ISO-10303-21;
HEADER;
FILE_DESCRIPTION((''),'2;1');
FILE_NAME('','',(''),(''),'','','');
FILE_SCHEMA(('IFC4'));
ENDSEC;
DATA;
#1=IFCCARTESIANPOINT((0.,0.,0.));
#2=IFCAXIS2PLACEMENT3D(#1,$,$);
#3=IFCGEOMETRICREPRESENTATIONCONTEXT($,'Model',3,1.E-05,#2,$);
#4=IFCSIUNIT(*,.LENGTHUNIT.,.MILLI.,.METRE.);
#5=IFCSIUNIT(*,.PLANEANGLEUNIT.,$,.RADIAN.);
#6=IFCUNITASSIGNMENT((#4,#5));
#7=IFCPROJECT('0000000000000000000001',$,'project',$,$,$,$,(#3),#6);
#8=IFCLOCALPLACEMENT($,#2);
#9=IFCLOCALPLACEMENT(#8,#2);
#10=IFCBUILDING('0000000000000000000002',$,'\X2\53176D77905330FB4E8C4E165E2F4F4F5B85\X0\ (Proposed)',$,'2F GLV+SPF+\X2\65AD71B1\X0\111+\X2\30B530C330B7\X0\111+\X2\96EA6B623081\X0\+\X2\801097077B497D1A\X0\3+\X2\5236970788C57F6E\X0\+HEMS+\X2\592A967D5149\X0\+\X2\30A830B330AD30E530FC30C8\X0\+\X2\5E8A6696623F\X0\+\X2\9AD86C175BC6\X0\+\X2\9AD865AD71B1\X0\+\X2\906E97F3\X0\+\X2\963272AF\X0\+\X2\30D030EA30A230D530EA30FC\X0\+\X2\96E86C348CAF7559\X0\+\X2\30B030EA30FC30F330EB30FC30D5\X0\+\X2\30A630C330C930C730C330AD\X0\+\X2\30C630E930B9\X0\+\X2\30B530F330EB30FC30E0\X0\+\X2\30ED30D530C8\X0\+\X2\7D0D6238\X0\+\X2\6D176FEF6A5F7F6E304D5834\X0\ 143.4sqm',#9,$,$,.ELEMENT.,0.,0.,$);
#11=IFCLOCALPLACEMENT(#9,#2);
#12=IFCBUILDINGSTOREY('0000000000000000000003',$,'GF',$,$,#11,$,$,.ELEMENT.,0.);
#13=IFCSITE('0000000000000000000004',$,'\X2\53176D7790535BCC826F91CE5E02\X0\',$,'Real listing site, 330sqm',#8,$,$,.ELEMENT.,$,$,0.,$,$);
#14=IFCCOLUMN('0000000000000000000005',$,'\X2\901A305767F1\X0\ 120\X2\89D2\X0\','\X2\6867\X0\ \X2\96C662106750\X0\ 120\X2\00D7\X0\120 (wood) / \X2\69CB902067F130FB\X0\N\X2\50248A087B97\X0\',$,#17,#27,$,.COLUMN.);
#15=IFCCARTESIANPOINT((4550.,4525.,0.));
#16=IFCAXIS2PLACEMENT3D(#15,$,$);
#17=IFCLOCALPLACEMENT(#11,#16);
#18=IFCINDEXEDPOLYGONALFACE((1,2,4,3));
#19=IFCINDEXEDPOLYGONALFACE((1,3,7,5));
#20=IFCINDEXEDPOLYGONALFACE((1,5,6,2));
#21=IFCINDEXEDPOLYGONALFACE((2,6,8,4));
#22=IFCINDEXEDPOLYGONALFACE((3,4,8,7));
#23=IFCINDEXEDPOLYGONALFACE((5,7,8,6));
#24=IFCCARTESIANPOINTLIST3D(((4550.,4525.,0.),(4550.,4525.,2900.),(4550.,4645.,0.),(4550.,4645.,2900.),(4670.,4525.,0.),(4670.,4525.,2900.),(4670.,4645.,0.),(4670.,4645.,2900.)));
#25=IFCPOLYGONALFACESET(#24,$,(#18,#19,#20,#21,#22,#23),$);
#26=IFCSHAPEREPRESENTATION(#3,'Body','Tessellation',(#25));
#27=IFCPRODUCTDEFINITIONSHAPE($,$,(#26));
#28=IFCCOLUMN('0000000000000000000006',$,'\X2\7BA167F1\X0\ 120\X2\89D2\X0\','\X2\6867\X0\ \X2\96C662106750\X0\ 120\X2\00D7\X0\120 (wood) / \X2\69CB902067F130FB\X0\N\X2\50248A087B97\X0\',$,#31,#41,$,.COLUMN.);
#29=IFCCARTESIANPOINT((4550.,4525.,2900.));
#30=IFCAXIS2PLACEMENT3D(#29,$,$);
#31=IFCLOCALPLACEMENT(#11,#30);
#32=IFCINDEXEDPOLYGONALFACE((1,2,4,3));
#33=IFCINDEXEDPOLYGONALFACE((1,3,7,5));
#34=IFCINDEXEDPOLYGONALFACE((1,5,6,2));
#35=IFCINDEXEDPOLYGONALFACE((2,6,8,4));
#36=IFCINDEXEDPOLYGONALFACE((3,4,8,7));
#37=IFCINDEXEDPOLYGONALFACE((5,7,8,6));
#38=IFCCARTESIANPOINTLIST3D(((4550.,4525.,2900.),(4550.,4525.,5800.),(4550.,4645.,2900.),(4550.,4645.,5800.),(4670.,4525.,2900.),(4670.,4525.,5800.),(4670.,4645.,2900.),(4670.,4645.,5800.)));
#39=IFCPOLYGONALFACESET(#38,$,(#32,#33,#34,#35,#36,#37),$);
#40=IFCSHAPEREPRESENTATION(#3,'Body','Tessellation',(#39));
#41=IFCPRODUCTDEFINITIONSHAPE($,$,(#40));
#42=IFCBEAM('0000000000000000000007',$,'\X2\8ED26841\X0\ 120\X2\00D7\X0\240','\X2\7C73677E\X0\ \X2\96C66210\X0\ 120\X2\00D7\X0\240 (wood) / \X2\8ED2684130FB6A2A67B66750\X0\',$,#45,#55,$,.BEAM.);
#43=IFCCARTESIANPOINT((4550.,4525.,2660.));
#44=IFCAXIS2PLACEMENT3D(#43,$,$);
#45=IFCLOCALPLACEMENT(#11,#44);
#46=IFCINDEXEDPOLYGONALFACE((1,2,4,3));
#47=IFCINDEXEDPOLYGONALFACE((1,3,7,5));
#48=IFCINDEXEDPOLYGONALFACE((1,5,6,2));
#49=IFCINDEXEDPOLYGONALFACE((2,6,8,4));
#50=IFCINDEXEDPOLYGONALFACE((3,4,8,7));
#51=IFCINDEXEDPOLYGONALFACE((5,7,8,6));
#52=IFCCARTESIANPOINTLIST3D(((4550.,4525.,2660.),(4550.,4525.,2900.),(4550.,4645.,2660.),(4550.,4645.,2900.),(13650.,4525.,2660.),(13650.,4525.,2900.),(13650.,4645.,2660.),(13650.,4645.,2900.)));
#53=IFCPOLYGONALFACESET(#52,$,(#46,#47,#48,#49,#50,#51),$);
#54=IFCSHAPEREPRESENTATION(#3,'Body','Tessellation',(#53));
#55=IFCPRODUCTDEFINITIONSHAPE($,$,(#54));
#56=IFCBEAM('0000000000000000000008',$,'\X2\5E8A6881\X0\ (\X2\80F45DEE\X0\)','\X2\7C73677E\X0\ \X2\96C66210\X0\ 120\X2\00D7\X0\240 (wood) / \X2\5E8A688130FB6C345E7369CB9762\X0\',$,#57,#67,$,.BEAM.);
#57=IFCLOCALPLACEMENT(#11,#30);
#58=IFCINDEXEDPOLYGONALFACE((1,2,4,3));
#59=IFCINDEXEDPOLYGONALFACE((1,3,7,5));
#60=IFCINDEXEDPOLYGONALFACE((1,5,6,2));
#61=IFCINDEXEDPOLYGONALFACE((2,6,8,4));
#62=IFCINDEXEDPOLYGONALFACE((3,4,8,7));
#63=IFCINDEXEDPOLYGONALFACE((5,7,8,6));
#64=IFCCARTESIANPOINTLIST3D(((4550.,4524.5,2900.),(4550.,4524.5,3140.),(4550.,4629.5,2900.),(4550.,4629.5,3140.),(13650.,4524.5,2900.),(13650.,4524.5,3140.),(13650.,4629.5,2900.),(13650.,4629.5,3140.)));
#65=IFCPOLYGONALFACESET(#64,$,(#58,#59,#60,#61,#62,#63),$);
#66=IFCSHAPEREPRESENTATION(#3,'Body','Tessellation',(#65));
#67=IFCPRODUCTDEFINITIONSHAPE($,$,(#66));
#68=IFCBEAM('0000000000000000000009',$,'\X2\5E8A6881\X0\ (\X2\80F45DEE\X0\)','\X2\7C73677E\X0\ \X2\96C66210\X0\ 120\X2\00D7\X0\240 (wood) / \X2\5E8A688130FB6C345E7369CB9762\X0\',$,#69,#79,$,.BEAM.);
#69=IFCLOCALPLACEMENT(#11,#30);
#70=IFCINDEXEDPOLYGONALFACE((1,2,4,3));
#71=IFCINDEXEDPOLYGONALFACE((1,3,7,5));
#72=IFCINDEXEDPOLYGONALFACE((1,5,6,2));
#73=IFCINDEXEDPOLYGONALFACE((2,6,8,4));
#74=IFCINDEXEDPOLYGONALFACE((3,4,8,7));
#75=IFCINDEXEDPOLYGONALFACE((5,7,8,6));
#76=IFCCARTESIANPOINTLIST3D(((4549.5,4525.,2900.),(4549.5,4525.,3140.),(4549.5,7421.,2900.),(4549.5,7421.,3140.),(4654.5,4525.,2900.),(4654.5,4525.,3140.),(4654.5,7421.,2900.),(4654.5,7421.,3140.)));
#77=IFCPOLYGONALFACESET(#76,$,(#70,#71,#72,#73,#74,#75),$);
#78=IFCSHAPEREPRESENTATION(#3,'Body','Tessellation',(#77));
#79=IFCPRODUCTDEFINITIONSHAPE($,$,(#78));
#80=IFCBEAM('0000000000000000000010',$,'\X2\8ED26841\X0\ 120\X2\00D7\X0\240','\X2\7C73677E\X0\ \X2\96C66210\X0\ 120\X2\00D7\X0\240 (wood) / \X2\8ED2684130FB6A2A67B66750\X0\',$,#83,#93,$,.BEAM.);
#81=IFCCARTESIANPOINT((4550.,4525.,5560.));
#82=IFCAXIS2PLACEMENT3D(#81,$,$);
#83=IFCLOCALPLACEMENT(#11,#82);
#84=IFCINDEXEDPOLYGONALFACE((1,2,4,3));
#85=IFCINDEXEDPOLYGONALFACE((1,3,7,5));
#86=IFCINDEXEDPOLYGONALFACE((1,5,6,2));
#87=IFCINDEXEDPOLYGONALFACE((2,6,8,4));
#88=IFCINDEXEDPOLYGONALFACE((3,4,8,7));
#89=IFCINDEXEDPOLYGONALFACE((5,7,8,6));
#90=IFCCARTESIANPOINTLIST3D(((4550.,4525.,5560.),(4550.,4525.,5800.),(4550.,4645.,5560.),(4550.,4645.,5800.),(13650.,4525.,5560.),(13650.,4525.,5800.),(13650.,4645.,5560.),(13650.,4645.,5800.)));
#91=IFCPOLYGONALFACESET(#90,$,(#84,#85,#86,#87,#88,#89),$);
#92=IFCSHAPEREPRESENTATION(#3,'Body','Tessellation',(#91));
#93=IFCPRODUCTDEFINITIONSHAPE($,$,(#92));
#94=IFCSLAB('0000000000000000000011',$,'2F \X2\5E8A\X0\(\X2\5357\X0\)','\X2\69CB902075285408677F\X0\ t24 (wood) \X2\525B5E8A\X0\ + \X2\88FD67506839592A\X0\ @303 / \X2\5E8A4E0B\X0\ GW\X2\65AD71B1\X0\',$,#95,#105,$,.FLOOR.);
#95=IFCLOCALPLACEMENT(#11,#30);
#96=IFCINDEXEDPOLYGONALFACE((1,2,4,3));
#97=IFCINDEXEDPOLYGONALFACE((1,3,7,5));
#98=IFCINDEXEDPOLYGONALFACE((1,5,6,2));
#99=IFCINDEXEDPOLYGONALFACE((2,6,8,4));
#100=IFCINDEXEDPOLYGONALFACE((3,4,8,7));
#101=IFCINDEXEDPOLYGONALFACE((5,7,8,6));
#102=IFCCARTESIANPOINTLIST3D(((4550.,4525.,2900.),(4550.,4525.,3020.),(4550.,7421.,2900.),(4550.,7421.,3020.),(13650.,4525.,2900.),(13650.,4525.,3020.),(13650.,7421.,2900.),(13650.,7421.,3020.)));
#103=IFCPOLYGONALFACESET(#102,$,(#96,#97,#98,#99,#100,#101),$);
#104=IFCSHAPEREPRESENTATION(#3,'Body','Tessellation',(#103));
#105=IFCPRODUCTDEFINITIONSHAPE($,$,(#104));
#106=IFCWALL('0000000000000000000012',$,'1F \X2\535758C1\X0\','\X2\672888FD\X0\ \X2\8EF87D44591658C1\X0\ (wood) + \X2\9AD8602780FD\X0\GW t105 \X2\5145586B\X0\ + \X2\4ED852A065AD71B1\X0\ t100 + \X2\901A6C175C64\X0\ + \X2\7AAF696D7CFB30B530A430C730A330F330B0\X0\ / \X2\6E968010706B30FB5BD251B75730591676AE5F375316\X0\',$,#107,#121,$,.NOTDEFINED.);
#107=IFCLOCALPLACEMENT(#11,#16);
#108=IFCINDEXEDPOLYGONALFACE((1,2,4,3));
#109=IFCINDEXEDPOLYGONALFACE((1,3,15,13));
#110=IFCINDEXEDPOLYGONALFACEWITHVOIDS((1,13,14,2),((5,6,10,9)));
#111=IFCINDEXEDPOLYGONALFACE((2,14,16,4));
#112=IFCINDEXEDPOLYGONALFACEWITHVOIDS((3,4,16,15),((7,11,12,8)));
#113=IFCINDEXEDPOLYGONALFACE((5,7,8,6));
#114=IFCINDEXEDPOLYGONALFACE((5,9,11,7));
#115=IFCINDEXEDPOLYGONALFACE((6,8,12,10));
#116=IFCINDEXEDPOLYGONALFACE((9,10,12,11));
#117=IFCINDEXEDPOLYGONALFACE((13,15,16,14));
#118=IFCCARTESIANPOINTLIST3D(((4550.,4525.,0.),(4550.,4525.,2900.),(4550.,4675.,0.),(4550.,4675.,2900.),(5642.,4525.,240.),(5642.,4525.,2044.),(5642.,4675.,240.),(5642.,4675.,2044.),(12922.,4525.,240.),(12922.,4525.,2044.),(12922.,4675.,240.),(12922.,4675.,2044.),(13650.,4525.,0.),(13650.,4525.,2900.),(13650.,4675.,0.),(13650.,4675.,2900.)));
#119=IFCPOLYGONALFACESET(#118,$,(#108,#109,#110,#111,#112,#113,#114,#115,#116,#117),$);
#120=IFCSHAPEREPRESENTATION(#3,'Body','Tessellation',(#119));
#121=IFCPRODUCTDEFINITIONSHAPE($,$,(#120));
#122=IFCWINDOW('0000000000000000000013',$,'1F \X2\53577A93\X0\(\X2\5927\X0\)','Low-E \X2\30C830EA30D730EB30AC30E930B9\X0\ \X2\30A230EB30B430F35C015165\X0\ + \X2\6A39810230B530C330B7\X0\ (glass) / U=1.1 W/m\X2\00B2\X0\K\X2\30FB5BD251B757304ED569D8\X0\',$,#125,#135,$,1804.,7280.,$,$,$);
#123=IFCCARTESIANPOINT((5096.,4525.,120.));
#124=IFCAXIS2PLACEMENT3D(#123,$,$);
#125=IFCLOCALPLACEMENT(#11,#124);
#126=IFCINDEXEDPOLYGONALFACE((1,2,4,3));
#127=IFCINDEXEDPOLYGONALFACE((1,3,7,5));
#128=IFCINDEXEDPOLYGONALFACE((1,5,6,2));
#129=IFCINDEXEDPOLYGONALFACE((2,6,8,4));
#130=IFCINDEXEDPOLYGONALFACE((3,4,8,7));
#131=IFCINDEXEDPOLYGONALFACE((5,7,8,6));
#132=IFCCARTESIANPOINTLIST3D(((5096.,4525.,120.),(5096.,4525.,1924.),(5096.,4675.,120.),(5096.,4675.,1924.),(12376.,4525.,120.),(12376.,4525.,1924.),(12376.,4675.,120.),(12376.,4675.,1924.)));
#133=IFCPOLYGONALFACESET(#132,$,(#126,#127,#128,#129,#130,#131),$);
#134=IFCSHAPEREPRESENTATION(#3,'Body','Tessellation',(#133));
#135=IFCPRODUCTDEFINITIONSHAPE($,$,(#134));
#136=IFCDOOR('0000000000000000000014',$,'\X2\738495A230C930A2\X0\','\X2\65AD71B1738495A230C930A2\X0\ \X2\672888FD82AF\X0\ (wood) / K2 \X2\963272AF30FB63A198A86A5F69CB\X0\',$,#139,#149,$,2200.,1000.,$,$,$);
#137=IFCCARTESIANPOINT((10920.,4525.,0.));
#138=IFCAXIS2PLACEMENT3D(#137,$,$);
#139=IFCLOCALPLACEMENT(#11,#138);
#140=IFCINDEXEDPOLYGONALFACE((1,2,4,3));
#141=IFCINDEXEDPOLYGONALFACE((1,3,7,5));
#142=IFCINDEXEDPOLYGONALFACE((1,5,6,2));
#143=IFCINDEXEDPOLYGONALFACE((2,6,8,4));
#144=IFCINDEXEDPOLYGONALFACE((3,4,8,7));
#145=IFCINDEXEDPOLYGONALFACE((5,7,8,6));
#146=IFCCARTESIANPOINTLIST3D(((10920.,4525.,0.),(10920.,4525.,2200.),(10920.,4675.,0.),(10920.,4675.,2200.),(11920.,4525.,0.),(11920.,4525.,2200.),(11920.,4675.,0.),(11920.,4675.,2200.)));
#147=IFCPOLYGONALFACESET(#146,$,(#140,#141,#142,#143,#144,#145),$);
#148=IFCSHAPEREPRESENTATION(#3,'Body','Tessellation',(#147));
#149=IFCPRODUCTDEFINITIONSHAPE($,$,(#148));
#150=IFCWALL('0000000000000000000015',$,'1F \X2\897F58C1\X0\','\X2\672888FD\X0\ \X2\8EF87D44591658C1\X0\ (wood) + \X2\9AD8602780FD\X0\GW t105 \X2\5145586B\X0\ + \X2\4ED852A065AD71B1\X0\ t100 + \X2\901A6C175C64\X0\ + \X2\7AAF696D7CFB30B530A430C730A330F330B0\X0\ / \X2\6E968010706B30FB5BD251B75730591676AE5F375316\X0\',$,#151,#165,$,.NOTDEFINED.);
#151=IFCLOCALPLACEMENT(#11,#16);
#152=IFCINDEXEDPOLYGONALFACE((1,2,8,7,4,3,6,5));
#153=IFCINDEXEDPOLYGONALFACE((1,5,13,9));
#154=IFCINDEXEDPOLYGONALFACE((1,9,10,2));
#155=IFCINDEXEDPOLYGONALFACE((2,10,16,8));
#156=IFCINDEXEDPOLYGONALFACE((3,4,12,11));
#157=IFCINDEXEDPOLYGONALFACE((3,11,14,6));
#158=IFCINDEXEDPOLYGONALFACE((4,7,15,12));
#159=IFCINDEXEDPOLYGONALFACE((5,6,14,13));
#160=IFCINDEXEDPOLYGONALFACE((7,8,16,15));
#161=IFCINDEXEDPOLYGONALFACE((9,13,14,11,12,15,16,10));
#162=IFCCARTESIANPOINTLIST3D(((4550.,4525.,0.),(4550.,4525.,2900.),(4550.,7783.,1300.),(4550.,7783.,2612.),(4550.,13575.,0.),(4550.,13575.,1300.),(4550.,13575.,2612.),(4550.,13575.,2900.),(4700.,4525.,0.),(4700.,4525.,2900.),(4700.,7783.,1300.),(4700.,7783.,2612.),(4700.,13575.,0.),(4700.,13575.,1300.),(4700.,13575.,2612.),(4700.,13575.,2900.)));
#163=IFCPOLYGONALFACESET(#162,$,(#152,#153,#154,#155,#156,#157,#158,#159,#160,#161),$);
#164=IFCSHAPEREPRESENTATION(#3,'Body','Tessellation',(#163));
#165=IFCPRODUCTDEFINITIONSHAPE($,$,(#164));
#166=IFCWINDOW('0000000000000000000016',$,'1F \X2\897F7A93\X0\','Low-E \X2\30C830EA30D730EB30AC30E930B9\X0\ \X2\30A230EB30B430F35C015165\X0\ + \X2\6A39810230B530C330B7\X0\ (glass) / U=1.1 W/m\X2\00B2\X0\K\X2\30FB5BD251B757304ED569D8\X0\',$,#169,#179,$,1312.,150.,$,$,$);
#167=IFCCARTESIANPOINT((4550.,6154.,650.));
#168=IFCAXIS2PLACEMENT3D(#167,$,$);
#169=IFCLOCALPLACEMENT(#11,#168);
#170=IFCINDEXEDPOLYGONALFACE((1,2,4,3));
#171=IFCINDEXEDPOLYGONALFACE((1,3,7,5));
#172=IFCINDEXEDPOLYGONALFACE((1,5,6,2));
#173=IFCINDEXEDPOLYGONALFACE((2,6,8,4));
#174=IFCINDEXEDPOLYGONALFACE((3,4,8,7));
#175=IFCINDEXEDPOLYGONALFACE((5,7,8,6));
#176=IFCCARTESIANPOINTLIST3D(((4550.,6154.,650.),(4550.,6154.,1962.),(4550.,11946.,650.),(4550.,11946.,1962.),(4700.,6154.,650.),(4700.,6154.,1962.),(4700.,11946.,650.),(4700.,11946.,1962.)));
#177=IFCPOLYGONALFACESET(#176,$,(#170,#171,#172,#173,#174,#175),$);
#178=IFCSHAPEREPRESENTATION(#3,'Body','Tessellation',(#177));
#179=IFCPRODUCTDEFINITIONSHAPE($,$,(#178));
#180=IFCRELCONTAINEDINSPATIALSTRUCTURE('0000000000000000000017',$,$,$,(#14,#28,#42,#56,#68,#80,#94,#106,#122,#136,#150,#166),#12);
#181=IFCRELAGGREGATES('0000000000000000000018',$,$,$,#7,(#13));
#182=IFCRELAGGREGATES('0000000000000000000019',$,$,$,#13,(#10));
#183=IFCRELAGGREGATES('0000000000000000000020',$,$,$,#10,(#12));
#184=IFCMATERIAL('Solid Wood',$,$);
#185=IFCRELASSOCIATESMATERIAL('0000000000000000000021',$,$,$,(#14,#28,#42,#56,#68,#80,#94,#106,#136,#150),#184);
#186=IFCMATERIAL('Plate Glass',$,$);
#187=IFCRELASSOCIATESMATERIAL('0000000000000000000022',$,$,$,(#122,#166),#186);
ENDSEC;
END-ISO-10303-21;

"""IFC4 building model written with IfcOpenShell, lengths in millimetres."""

from ifc_helpers import new_model, si_unit, frame, frame_2d, origin, place, context, project, spatial, rectangle, extrude, material, element, fill, save


model = new_model("IFC4")

# Units and contexts
model_context = context("Model", 3, precision=1e-05, world=origin())
ifc_project = project(units=[si_unit("LENGTHUNIT", "METRE", prefix="MILLI"), si_unit("PLANEANGLEUNIT", "RADIAN")], contexts=[model_context])

# Site, building, storey
site_placement = place(None, origin())
site = spatial("IfcSite", under=ifc_project, at=site_placement, Name="北海道富良野市", ObjectType="Real listing site, 330sqm", CompositionType="ELEMENT", RefElevation=0.0)
building_placement = place(site_placement, origin())
building = spatial("IfcBuilding", under=site, at=building_placement, Name="北海道・二世帯住宅 (Proposed)", ObjectType="2F GLV+SPF+断熱111+サッシ111+雪止め+耐震等級3+制震装置+HEMS+太陽光+エコキュート+床暖房+高気密+高断熱+遮音+防犯+バリアフリー+雨水貯留+グリーンルーフ+ウッドデッキ+テラス+サンルーム+ロフト+納戸+洗濯機置き場 143.4sqm", CompositionType="ELEMENT", ElevationOfRefHeight=0.0, ElevationOfTerrain=0.0)
storey_placement = place(building_placement, origin())
storey = spatial("IfcBuildingStorey", under=building, at=storey_placement, Name="GF", CompositionType="ELEMENT", Elevation=0.0)

# Columns
ifc_material_1 = material(Name="Solid Wood")
column_1_placement = place(storey_placement, frame((4550.0, 4525.0, 0.0)))
element("IfcColumn", 1, at=column_1_placement, inside=storey, material=ifc_material_1, Name="通し柱 120角", Description="桧 集成材 120×120 (wood) / 構造柱・N値計算", PredefinedType="COLUMN", context=model_context, shape_type="SweptSolid", body=[
    extrude(rectangle(XDim=120.0, YDim=120.0, at=frame_2d((60.0, 60.0))), frame((4550.0, 4525.0, 0.0)), (0.0, 0.0, 1.0), 2900.0),
])
column_2_placement = place(storey_placement, frame((4550.0, 4525.0, 2900.0)))
element("IfcColumn", 2, at=column_2_placement, inside=storey, material=ifc_material_1, Name="管柱 120角", Description="桧 集成材 120×120 (wood) / 構造柱・N値計算", PredefinedType="COLUMN", context=model_context, shape_type="SweptSolid", body=[
    extrude(rectangle(XDim=120.0, YDim=120.0, at=frame_2d((60.0, 60.0))), frame((4550.0, 4525.0, 2900.0)), (0.0, 0.0, 1.0), 2900.0),
])

# Beams
beam_1_placement = place(storey_placement, frame((4550.0, 4525.0, 2660.0)))
element("IfcBeam", 3, at=beam_1_placement, inside=storey, material=ifc_material_1, Name="軒桁 120×240", Description="米松 集成 120×240 (wood) / 軒桁・横架材", PredefinedType="BEAM", context=model_context, shape_type="SweptSolid", body=[
    extrude(rectangle(XDim=9100.0, YDim=120.0, at=frame_2d((4550.0, 60.0))), frame((4550.0, 4525.0, 2660.0)), (0.0, 0.0, 1.0), 240.0),
])
beam_2_placement = place(storey_placement, frame((4550.0, 4525.0, 2900.0)))
element("IfcBeam", 4, at=beam_2_placement, inside=storey, material=ifc_material_1, Name="床梁 (胴差)", Description="米松 集成 120×240 (wood) / 床梁・水平構面", PredefinedType="BEAM", context=model_context, shape_type="SweptSolid", body=[
    extrude(rectangle(XDim=9100.0, YDim=105.0, at=frame_2d((4550.0, 52.0))), frame((4550.0, 4525.0, 2900.0)), (0.0, 0.0, 1.0), 240.0),
])
beam_3_placement = place(storey_placement, frame((4550.0, 4525.0, 2900.0)))
element("IfcBeam", 5, at=beam_3_placement, inside=storey, material=ifc_material_1, Name="床梁 (胴差)", Description="米松 集成 120×240 (wood) / 床梁・水平構面", PredefinedType="BEAM", context=model_context, shape_type="SweptSolid", body=[
    extrude(rectangle(XDim=105.0, YDim=2896.0, at=frame_2d((52.0, 1448.0))), frame((4550.0, 4525.0, 2900.0)), (0.0, 0.0, 1.0), 240.0),
])
beam_4_placement = place(storey_placement, frame((4550.0, 4525.0, 5560.0)))
element("IfcBeam", 6, at=beam_4_placement, inside=storey, material=ifc_material_1, Name="軒桁 120×240", Description="米松 集成 120×240 (wood) / 軒桁・横架材", PredefinedType="BEAM", context=model_context, shape_type="SweptSolid", body=[
    extrude(rectangle(XDim=9100.0, YDim=120.0, at=frame_2d((4550.0, 60.0))), frame((4550.0, 4525.0, 5560.0)), (0.0, 0.0, 1.0), 240.0),
])

# Slab
slab_1_placement = place(storey_placement, frame((4550.0, 4525.0, 2900.0)))
element("IfcSlab", 7, at=slab_1_placement, inside=storey, material=ifc_material_1, Name="2F 床(南)", Description="構造用合板 t24 (wood) 剛床 + 製材根太 @303 / 床下 GW断熱", PredefinedType="FLOOR", context=model_context, shape_type="SweptSolid", body=[
    extrude(rectangle(XDim=9100.0, YDim=2896.0, at=frame_2d((4550.0, 1448.0))), frame((4550.0, 4525.0, 2900.0)), (0.0, 0.0, 1.0), 120.0),
])

# Wall, openings, window, door
wall_1_placement = place(storey_placement, frame((4550.0, 4525.0, 0.0)))
wall_1 = element("IfcWall", 8, at=wall_1_placement, inside=storey, material=ifc_material_1, Name="1F 南壁", Description="木製 軸組外壁 (wood) + 高性能GW t105 充填 + 付加断熱 t100 + 通気層 + 窯業系サイディング / 準耐火・寒冷地外皮強化", PredefinedType="NOTDEFINED", context=model_context, shape_type="SweptSolid", body=[
    extrude(rectangle(XDim=9100.0, YDim=150.0, at=frame_2d((4550.0, 75.0))), frame((4550.0, 4525.0, 0.0)), (0.0, 0.0, 1.0), 2900.0),
])
opening_1_placement = place(storey_placement, frame((5096.0, 4525.0, 120.0)))
opening_1 = element("IfcOpeningElement", 9, at=opening_1_placement, cuts=wall_1, PredefinedType="NOTDEFINED", context=model_context, shape_type="SweptSolid", body=[
    extrude(rectangle(XDim=7280.0, YDim=150.0, at=frame_2d((3640.0, 75.0))), frame((5096.0, 4525.0, 120.0)), (0.0, 0.0, 1.0), 1804.0),
])
opening_2_placement = place(storey_placement, frame((10920.0, 4525.0, 0.0)))
opening_2 = element("IfcOpeningElement", 10, at=opening_2_placement, cuts=wall_1, PredefinedType="NOTDEFINED", context=model_context, shape_type="SweptSolid", body=[
    extrude(rectangle(XDim=1000.0, YDim=150.0, at=frame_2d((500.0, 75.0))), frame((10920.0, 4525.0, 0.0)), (0.0, 0.0, 1.0), 2200.0),
])
ifc_material_2 = material(Name="Plate Glass")
window_1_placement = place(storey_placement, frame((5096.0, 4525.0, 120.0)))
window_1 = element("IfcWindow", 11, at=window_1_placement, inside=storey, material=ifc_material_2, Name="1F 南窓(大)", Description="Low-E トリプルガラス アルゴン封入 + 樹脂サッシ (glass) / U=1.1 W/m²K・寒冷地仕様", OverallHeight=1804.0, OverallWidth=7280.0, context=model_context, shape_type="SweptSolid", body=[
    extrude(rectangle(XDim=7280.0, YDim=150.0, at=frame_2d((3640.0, 75.0))), frame((5096.0, 4525.0, 120.0)), (0.0, 0.0, 1.0), 1804.0),
])
fill(opening_1, window_1)
door_placement = place(storey_placement, frame((10920.0, 4525.0, 0.0)))
door = element("IfcDoor", 12, at=door_placement, inside=storey, material=ifc_material_1, Name="玄関ドア", Description="断熱玄関ドア 木製芯 (wood) / K2 防犯・採風機構", OverallHeight=2200.0, OverallWidth=1000.0, context=model_context, shape_type="SweptSolid", body=[
    extrude(rectangle(XDim=1000.0, YDim=150.0, at=frame_2d((500.0, 75.0))), frame((10920.0, 4525.0, 0.0)), (0.0, 0.0, 1.0), 2200.0),
])
fill(opening_2, door)

# Wall, opening, window
wall_2_placement = place(storey_placement, frame((4550.0, 4525.0, 0.0)))
wall_2 = element("IfcWall", 13, at=wall_2_placement, inside=storey, material=ifc_material_1, Name="1F 西壁", Description="木製 軸組外壁 (wood) + 高性能GW t105 充填 + 付加断熱 t100 + 通気層 + 窯業系サイディング / 準耐火・寒冷地外皮強化", PredefinedType="NOTDEFINED", context=model_context, shape_type="SweptSolid", body=[
    extrude(rectangle(XDim=150.0, YDim=9050.0, at=frame_2d((75.0, 4525.0))), frame((4550.0, 4525.0, 0.0)), (0.0, 0.0, 1.0), 2900.0),
])
opening_3_placement = place(storey_placement, frame((4550.0, 6154.0, 650.0)))
opening_3 = element("IfcOpeningElement", 14, at=opening_3_placement, cuts=wall_2, PredefinedType="NOTDEFINED", context=model_context, shape_type="SweptSolid", body=[
    extrude(rectangle(XDim=150.0, YDim=5792.0, at=frame_2d((75.0, 2896.0))), frame((4550.0, 6154.0, 650.0)), (0.0, 0.0, 1.0), 1312.0),
])
window_2_placement = place(storey_placement, frame((4550.0, 6154.0, 650.0)))
window_2 = element("IfcWindow", 15, at=window_2_placement, inside=storey, material=ifc_material_2, Name="1F 西窓", Description="Low-E トリプルガラス アルゴン封入 + 樹脂サッシ (glass) / U=1.1 W/m²K・寒冷地仕様", OverallHeight=1312.0, OverallWidth=150.0, context=model_context, shape_type="SweptSolid", body=[
    extrude(rectangle(XDim=150.0, YDim=5792.0, at=frame_2d((75.0, 2896.0))), frame((4550.0, 6154.0, 650.0)), (0.0, 0.0, 1.0), 1312.0),
])
fill(opening_3, window_2)

save(model, "model.ifc")
